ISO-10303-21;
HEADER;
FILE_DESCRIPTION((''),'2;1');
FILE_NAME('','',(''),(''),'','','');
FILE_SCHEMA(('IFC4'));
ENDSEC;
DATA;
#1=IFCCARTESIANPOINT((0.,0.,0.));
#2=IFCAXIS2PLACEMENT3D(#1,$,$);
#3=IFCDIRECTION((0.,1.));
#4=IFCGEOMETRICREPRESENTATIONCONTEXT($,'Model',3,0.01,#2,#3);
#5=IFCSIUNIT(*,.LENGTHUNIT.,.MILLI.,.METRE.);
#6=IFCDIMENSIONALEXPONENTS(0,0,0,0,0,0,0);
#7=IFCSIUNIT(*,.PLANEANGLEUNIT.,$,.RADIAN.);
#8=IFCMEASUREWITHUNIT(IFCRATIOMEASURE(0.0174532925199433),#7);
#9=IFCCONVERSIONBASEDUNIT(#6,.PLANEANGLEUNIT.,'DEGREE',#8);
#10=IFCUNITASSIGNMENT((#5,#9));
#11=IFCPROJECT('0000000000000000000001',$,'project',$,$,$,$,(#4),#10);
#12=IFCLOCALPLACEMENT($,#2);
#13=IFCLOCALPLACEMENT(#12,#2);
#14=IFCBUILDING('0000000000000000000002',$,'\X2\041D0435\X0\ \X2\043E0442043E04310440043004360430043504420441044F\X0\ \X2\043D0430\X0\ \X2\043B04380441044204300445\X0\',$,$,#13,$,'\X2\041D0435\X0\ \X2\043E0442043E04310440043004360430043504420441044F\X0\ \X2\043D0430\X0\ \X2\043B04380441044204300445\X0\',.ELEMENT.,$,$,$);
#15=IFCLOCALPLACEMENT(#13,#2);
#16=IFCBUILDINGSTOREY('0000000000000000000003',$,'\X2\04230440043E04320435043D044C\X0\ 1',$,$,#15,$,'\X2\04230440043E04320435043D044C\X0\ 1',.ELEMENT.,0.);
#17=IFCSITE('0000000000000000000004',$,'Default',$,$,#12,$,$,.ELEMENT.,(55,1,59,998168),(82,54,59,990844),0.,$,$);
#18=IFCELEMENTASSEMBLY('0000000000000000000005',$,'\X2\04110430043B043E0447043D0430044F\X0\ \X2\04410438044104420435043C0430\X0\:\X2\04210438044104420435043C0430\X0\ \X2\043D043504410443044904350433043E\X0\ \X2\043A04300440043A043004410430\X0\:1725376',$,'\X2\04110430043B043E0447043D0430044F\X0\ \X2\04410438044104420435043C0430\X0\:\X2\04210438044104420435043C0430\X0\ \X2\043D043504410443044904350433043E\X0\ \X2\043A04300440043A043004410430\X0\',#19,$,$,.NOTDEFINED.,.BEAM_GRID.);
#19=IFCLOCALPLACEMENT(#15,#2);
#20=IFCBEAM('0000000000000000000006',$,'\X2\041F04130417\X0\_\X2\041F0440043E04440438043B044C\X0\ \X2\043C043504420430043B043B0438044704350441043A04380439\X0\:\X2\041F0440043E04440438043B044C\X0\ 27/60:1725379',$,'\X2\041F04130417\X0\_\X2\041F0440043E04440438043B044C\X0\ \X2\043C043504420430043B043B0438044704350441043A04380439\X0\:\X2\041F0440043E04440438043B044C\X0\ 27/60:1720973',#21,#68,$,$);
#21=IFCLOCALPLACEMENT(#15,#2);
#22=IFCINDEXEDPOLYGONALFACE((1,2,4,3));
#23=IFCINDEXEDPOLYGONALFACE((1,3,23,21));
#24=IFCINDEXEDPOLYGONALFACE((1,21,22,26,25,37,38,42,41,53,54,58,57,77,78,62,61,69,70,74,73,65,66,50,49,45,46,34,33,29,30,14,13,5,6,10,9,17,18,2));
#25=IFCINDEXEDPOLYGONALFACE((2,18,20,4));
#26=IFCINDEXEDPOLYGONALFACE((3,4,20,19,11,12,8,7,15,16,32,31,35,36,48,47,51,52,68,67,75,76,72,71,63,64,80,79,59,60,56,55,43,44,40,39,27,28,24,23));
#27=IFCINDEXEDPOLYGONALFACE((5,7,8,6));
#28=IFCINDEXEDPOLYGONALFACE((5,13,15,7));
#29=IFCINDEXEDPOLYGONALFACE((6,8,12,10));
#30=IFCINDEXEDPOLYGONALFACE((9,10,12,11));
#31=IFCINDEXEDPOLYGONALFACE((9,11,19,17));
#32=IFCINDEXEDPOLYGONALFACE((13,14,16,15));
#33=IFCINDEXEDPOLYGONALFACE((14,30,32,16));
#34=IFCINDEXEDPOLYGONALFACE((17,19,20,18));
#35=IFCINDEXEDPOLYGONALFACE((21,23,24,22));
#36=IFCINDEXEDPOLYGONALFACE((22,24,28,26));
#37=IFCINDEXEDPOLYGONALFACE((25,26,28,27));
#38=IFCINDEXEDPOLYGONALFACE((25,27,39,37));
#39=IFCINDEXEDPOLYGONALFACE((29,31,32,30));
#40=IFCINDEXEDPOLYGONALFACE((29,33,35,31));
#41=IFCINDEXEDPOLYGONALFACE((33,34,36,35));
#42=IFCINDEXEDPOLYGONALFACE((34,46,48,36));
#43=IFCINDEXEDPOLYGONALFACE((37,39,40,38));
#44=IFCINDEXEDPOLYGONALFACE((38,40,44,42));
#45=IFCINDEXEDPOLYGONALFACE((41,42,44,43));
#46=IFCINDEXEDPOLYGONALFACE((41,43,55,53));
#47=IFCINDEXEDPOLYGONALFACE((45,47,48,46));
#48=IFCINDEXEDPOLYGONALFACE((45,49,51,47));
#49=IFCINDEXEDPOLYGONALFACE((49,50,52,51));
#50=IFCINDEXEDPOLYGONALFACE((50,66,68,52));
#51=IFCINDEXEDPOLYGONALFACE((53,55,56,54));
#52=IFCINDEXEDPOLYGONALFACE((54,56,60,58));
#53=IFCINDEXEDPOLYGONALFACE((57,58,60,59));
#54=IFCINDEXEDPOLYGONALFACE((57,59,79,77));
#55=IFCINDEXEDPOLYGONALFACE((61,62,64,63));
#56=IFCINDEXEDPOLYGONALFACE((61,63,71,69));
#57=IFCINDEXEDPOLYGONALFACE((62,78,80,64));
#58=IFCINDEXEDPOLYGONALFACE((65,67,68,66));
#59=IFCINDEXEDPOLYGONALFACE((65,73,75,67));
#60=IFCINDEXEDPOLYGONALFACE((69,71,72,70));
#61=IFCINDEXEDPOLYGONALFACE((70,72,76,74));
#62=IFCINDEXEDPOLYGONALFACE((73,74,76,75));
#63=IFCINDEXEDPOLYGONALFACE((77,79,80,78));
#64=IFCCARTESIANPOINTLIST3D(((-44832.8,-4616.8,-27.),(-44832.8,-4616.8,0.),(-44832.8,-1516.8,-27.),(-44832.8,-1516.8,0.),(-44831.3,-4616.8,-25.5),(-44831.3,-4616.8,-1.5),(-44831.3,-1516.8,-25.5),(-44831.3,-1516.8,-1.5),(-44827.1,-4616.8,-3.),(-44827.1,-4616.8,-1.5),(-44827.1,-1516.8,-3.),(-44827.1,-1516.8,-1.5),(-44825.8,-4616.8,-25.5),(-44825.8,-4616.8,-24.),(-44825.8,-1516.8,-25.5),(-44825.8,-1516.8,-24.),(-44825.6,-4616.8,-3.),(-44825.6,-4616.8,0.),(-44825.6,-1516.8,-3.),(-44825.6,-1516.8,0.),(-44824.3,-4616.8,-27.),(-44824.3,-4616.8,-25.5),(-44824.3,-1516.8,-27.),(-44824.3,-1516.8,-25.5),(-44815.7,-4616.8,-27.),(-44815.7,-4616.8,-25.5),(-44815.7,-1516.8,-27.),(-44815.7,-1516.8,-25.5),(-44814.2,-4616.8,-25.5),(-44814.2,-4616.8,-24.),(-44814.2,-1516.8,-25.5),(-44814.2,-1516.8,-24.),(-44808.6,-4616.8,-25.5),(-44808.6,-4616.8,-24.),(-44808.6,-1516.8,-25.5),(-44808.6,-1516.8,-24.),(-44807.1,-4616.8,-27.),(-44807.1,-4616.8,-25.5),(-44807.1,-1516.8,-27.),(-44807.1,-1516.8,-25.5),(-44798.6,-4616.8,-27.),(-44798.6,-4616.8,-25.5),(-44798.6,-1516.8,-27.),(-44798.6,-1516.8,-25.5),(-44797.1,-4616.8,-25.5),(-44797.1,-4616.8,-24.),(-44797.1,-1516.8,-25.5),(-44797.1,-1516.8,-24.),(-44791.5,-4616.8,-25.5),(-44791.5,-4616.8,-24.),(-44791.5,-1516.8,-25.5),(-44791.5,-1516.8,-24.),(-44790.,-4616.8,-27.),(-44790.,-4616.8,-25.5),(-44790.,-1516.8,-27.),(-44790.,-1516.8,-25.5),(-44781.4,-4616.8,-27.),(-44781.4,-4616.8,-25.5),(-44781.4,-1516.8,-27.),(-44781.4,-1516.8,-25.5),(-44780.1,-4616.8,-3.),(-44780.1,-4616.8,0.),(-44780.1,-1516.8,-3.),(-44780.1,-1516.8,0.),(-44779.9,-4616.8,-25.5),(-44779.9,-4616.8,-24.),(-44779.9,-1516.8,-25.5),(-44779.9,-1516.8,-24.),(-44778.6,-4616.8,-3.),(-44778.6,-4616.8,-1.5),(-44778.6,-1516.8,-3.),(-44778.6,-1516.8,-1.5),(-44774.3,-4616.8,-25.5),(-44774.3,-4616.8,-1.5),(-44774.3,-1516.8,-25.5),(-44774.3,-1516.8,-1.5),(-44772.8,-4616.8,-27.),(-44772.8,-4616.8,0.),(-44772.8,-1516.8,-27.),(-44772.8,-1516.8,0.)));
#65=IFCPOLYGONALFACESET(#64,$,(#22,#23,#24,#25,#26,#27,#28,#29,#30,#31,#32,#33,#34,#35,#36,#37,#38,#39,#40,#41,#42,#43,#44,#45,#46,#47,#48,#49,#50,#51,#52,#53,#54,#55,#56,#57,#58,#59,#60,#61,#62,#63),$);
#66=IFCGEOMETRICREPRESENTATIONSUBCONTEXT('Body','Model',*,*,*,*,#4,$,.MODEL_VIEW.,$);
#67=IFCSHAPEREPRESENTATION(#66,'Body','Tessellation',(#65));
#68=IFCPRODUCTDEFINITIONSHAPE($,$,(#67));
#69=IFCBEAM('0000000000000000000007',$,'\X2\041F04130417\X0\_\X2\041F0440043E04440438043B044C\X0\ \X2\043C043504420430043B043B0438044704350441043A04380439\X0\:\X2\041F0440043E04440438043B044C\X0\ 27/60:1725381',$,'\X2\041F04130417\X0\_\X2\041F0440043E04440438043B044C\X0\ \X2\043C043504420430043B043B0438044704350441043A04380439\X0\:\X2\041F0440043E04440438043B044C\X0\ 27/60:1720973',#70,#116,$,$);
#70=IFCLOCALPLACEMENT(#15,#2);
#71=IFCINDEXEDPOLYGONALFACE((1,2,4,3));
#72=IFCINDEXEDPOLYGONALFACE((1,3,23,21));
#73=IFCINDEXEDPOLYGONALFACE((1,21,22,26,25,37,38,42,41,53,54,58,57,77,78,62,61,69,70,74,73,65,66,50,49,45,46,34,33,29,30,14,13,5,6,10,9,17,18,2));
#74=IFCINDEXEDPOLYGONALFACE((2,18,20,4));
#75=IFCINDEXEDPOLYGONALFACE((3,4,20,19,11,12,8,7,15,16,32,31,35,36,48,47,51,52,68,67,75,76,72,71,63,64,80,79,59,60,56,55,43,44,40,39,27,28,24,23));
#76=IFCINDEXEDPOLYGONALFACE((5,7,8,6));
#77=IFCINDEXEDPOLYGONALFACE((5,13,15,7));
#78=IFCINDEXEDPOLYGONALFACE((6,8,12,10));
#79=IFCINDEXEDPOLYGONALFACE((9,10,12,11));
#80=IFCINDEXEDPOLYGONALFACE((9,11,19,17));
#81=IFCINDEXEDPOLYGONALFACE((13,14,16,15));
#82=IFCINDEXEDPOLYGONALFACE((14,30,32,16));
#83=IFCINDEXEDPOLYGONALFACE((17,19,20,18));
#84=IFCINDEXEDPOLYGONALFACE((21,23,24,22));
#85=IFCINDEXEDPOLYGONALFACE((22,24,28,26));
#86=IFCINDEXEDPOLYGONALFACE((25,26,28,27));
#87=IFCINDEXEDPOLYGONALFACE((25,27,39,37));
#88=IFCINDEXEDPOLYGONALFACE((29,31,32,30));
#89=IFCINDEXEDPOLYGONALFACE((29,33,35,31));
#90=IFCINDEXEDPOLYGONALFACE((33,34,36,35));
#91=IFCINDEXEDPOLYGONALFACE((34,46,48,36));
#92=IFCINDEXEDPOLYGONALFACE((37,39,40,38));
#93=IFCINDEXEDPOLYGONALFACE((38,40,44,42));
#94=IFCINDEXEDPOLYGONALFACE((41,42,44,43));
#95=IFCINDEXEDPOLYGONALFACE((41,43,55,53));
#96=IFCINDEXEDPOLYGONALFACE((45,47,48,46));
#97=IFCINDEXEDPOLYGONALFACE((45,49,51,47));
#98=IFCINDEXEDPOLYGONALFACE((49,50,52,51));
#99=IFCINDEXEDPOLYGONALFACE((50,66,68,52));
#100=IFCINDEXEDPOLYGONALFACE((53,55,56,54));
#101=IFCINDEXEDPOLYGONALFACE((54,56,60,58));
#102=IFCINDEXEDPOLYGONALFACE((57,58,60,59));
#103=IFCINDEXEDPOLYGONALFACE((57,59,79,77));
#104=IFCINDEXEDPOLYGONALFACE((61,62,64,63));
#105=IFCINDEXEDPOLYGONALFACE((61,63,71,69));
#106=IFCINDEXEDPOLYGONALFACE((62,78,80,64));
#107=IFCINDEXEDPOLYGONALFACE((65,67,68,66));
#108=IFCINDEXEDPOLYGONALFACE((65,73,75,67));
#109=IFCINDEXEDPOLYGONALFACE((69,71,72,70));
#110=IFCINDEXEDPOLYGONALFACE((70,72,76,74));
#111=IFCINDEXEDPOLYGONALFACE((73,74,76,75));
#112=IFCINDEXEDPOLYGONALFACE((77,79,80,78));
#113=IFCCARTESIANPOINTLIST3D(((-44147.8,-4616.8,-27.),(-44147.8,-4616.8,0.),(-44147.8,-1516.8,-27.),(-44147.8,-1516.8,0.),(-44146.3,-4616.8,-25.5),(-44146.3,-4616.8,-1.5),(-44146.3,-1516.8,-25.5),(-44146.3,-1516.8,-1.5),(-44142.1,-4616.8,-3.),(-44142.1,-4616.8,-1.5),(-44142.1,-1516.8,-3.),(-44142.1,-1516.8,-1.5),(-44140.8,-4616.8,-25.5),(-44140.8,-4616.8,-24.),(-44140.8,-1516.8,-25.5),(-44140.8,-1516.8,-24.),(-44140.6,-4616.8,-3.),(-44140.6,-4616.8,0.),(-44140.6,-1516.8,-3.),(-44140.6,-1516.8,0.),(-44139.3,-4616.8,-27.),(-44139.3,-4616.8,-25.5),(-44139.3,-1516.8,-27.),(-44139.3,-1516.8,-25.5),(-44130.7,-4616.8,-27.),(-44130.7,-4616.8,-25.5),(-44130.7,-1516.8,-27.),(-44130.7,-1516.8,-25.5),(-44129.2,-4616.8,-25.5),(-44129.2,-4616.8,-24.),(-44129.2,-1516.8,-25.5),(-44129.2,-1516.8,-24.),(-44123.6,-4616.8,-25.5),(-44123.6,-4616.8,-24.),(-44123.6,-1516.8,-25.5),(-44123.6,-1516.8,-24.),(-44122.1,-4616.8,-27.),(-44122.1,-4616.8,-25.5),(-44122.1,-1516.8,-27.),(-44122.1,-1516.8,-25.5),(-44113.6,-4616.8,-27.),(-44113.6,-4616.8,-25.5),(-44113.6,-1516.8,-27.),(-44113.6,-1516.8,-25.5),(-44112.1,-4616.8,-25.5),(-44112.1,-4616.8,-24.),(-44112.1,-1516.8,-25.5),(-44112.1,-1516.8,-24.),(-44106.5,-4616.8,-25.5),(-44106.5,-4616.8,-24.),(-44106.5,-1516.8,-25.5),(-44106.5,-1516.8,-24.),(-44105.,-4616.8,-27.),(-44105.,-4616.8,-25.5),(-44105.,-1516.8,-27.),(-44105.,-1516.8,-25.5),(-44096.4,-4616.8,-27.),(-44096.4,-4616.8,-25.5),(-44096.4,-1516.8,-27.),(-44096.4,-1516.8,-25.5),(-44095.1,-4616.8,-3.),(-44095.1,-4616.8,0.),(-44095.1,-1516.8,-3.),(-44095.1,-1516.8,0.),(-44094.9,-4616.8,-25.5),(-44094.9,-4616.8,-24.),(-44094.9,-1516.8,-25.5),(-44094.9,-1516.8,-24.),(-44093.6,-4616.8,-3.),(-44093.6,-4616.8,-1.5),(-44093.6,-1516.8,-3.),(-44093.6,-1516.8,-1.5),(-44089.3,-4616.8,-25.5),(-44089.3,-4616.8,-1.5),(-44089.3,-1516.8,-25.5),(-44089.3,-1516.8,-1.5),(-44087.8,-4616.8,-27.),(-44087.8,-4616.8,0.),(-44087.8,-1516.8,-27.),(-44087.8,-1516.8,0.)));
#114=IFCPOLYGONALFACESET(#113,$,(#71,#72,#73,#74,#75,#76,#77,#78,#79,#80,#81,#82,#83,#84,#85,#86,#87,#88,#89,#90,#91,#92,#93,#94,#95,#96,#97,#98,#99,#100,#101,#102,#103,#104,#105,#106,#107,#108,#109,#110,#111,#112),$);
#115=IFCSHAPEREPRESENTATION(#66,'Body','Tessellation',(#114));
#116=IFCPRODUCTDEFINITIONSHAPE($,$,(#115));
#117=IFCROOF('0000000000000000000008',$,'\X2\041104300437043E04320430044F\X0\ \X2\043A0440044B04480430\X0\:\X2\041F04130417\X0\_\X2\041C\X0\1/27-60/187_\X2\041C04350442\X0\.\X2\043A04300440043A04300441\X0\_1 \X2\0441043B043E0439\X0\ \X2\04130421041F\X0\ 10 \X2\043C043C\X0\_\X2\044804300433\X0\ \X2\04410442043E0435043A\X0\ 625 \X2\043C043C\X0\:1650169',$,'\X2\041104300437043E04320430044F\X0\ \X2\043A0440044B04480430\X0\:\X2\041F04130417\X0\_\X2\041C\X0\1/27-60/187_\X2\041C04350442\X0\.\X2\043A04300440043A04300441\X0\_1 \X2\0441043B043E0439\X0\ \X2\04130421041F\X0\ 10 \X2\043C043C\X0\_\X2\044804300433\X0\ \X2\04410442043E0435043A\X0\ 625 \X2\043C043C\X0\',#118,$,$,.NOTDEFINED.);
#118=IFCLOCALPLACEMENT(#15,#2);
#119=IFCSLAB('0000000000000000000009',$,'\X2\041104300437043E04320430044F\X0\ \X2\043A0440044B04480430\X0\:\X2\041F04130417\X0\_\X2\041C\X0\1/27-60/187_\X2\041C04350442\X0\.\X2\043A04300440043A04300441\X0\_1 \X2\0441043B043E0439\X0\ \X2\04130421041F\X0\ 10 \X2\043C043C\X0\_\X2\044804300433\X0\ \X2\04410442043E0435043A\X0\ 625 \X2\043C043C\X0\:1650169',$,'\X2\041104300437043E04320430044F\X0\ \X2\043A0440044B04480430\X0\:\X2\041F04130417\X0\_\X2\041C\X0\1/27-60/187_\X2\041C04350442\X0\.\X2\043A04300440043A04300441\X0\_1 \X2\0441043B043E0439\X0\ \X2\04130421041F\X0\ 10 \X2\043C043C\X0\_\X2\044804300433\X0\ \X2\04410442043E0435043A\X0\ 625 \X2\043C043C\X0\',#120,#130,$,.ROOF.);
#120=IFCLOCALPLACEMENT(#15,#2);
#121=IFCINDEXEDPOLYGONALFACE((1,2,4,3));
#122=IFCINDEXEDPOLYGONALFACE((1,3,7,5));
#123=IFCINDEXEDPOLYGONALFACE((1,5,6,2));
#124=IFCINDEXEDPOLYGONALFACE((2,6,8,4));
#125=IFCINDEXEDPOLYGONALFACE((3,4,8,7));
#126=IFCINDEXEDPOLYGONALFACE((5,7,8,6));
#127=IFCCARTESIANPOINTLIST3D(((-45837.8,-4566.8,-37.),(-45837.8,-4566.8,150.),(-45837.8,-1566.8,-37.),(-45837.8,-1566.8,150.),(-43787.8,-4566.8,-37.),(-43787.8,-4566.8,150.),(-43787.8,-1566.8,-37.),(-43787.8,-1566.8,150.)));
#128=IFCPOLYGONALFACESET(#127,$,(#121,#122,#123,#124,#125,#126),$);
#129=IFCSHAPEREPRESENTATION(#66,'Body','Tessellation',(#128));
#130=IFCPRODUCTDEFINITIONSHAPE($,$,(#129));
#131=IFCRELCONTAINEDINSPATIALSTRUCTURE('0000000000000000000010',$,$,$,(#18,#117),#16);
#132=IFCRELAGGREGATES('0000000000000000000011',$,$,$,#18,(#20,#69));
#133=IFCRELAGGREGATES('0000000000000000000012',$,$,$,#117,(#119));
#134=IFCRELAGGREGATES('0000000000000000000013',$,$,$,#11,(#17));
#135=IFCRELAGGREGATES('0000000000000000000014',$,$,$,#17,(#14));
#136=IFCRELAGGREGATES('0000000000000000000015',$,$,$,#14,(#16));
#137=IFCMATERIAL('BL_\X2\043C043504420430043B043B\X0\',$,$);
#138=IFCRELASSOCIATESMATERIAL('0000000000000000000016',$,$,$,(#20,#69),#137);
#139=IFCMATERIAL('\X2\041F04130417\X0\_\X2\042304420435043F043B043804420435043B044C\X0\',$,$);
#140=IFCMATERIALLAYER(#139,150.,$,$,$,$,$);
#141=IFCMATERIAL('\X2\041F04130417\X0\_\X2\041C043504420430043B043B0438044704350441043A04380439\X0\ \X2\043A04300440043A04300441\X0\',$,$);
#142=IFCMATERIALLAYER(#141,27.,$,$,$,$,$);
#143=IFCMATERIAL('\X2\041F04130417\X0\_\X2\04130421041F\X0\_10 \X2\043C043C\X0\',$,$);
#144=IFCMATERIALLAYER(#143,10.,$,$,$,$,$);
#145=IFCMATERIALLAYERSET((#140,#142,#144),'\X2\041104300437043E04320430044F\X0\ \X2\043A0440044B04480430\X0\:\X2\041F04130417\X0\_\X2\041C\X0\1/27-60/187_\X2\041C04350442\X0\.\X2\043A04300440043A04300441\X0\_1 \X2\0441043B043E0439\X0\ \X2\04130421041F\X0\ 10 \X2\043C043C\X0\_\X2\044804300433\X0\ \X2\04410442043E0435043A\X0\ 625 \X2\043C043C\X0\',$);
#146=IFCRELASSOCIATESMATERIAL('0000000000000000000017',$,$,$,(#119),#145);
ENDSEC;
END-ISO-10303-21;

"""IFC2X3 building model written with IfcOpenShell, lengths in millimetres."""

from ifc_helpers import new_model, entity, si_unit, converted_unit, direction, frame, frame_2d, origin, place, context, subcontext, project, spatial, polyline, rectangle, outline, extrude, material, layer, layer_set, element, aggregate, save


model = new_model("IFC2X3")

# Units and contexts
model_context = context("Model", 3, precision=0.01, world=origin(), true_north=direction((0.0, 1.0)))
body_context = subcontext(model_context, "Body", "Model", "MODEL_VIEW")
ifc_project = project(units=[si_unit("LENGTHUNIT", "METRE", prefix="MILLI"), converted_unit("PLANEANGLEUNIT", "DEGREE", entity("IfcRatioMeasure", 0.0174532925199433), si_unit("PLANEANGLEUNIT", "RADIAN"), dimensions=[0, 0, 0, 0, 0, 0, 0])], contexts=[model_context])

# Site, building, storey
site_placement = place(None, origin())
site = spatial("IfcSite", under=ifc_project, at=site_placement, Name="Default", CompositionType="ELEMENT", RefLatitude=(55, 1, 59, 998168), RefLongitude=(82, 54, 59, 990844), RefElevation=0.0)
building_placement = place(site_placement, origin())
building = spatial("IfcBuilding", under=site, at=building_placement, Name="Не отображается на листах", LongName="Не отображается на листах", CompositionType="ELEMENT")
storey_placement = place(building_placement, frame((0.0, 0.0, 0.0)))
storey = spatial("IfcBuildingStorey", under=building, at=storey_placement, Name="Уровень 1", LongName="Уровень 1", CompositionType="ELEMENT", Elevation=0.0)

# Element assembly, beams
ifc_material_1 = material(Name="BL_металл")
assembly_1_placement = place(storey_placement, origin())
assembly_1 = element("IfcElementAssembly", 1, at=assembly_1_placement, inside=storey, Name="Балочная система:Система несущего каркаса:1725376", ObjectType="Балочная система:Система несущего каркаса", AssemblyPlace="NOTDEFINED", PredefinedType="BEAM_GRID")
beam_1_placement = place(assembly_1_placement, frame((-44802.8, -4616.8, 0.0), z_axis=(0.0, 0.0, 1.0), x_axis=(0.0, 1.0, 0.0)))
beam_1 = element("IfcBeam", 2, at=beam_1_placement, material=ifc_material_1, Name="ПГЗ_Профиль металлический:Профиль 27/60:1725379", ObjectType="ПГЗ_Профиль металлический:Профиль 27/60:1720973", context=body_context, shape_type="SweptSolid", body=[
    extrude(outline(polyline([(-18.4, -30.0), (8.6, -30.0), (8.6, -21.4), (7.1, -21.4), (7.1, -12.9), (8.6, -12.9), (8.6, -4.3), (7.1, -4.3), (7.1, 4.3), (8.6, 4.3), (8.6, 12.9), (7.1, 12.9), (7.1, 21.4), (8.6, 21.4), (8.6, 30.0), (-18.4, 30.0), (-18.4, 22.7), (-15.4, 22.7), (-15.4, 24.2), (-16.9, 24.2), (-16.9, 28.5), (7.1, 28.5), (7.1, 22.9), (5.6, 22.9), (5.6, 11.4), (7.1, 11.4), (7.1, 5.8), (5.6, 5.8), (5.6, -5.8), (7.1, -5.8), (7.1, -11.4), (5.6, -11.4), (5.6, -22.9), (7.1, -22.9), (7.1, -28.5), (-16.9, -28.5), (-16.9, -24.2), (-15.4, -24.2), (-15.4, -22.7), (-18.4, -22.7), (-18.4, -30.0)])), frame((0.0, 0.0, -18.4), z_axis=(1.0, 0.0, 0.0), x_axis=(0.0, 0.0, -1.0)), (0.0, 0.0, 1.0), 3100.0),
])
beam_2_placement = place(assembly_1_placement, frame((-44117.8, -4616.8, 0.0), z_axis=(0.0, 0.0, 1.0), x_axis=(0.0, 1.0, 0.0)))
beam_2 = element("IfcBeam", 3, at=beam_2_placement, material=ifc_material_1, Name="ПГЗ_Профиль металлический:Профиль 27/60:1725381", ObjectType="ПГЗ_Профиль металлический:Профиль 27/60:1720973", context=body_context, shape_type="SweptSolid", body=[
    extrude(outline(polyline([(-18.4, -30.0), (8.6, -30.0), (8.6, -21.4), (7.1, -21.4), (7.1, -12.9), (8.6, -12.9), (8.6, -4.3), (7.1, -4.3), (7.1, 4.3), (8.6, 4.3), (8.6, 12.9), (7.1, 12.9), (7.1, 21.4), (8.6, 21.4), (8.6, 30.0), (-18.4, 30.0), (-18.4, 22.7), (-15.4, 22.7), (-15.4, 24.2), (-16.9, 24.2), (-16.9, 28.5), (7.1, 28.5), (7.1, 22.9), (5.6, 22.9), (5.6, 11.4), (7.1, 11.4), (7.1, 5.8), (5.6, 5.8), (5.6, -5.8), (7.1, -5.8), (7.1, -11.4), (5.6, -11.4), (5.6, -22.9), (7.1, -22.9), (7.1, -28.5), (-16.9, -28.5), (-16.9, -24.2), (-15.4, -24.2), (-15.4, -22.7), (-18.4, -22.7), (-18.4, -30.0)])), frame((0.0, 0.0, -18.4), z_axis=(1.0, 0.0, 0.0), x_axis=(0.0, 0.0, -1.0)), (0.0, 0.0, 1.0), 3100.0),
])
aggregate(assembly_1, [beam_1, beam_2])

# Roof, slab
roof_placement = place(storey_placement, frame((-45837.8, -4566.8, -37.0)))
roof = element("IfcRoof", 4, at=roof_placement, inside=storey, Name="Базовая крыша:ПГЗ_М1/27-60/187_Мет.каркас_1 слой ГСП 10 мм_шаг стоек 625 мм:1650169", ObjectType="Базовая крыша:ПГЗ_М1/27-60/187_Мет.каркас_1 слой ГСП 10 мм_шаг стоек 625 мм", ShapeType="NOTDEFINED")
ifc_material_2 = material(Name="ПГЗ_Утеплитель")
ifc_layer_1 = layer(ifc_material_2, 150.0)
ifc_material_3 = material(Name="ПГЗ_Металлический каркас")
ifc_layer_2 = layer(ifc_material_3, 27.0)
ifc_material_4 = material(Name="ПГЗ_ГСП_10 мм")
ifc_layer_3 = layer(ifc_material_4, 10.0)
ifc_layer_set = layer_set([ifc_layer_1, ifc_layer_2, ifc_layer_3], Name="Базовая крыша:ПГЗ_М1/27-60/187_Мет.каркас_1 слой ГСП 10 мм_шаг стоек 625 мм")
slab_placement = place(roof_placement, origin())
slab = element("IfcSlab", 5, at=slab_placement, material=ifc_layer_set, Name="Базовая крыша:ПГЗ_М1/27-60/187_Мет.каркас_1 слой ГСП 10 мм_шаг стоек 625 мм:1650169", ObjectType="Базовая крыша:ПГЗ_М1/27-60/187_Мет.каркас_1 слой ГСП 10 мм_шаг стоек 625 мм", PredefinedType="ROOF", context=body_context, shape_type="SweptSolid", body=[
    extrude(rectangle(XDim=2050.0, YDim=3000.0, at=frame_2d((0.0, 0.0), x_axis=(1.0, 0.0))), frame((1025.0, 1500.0, 0.0)), (0.0, 0.0, 1.0), 187.0),
])
aggregate(roof, [slab])

save(model, "model.ifc")
